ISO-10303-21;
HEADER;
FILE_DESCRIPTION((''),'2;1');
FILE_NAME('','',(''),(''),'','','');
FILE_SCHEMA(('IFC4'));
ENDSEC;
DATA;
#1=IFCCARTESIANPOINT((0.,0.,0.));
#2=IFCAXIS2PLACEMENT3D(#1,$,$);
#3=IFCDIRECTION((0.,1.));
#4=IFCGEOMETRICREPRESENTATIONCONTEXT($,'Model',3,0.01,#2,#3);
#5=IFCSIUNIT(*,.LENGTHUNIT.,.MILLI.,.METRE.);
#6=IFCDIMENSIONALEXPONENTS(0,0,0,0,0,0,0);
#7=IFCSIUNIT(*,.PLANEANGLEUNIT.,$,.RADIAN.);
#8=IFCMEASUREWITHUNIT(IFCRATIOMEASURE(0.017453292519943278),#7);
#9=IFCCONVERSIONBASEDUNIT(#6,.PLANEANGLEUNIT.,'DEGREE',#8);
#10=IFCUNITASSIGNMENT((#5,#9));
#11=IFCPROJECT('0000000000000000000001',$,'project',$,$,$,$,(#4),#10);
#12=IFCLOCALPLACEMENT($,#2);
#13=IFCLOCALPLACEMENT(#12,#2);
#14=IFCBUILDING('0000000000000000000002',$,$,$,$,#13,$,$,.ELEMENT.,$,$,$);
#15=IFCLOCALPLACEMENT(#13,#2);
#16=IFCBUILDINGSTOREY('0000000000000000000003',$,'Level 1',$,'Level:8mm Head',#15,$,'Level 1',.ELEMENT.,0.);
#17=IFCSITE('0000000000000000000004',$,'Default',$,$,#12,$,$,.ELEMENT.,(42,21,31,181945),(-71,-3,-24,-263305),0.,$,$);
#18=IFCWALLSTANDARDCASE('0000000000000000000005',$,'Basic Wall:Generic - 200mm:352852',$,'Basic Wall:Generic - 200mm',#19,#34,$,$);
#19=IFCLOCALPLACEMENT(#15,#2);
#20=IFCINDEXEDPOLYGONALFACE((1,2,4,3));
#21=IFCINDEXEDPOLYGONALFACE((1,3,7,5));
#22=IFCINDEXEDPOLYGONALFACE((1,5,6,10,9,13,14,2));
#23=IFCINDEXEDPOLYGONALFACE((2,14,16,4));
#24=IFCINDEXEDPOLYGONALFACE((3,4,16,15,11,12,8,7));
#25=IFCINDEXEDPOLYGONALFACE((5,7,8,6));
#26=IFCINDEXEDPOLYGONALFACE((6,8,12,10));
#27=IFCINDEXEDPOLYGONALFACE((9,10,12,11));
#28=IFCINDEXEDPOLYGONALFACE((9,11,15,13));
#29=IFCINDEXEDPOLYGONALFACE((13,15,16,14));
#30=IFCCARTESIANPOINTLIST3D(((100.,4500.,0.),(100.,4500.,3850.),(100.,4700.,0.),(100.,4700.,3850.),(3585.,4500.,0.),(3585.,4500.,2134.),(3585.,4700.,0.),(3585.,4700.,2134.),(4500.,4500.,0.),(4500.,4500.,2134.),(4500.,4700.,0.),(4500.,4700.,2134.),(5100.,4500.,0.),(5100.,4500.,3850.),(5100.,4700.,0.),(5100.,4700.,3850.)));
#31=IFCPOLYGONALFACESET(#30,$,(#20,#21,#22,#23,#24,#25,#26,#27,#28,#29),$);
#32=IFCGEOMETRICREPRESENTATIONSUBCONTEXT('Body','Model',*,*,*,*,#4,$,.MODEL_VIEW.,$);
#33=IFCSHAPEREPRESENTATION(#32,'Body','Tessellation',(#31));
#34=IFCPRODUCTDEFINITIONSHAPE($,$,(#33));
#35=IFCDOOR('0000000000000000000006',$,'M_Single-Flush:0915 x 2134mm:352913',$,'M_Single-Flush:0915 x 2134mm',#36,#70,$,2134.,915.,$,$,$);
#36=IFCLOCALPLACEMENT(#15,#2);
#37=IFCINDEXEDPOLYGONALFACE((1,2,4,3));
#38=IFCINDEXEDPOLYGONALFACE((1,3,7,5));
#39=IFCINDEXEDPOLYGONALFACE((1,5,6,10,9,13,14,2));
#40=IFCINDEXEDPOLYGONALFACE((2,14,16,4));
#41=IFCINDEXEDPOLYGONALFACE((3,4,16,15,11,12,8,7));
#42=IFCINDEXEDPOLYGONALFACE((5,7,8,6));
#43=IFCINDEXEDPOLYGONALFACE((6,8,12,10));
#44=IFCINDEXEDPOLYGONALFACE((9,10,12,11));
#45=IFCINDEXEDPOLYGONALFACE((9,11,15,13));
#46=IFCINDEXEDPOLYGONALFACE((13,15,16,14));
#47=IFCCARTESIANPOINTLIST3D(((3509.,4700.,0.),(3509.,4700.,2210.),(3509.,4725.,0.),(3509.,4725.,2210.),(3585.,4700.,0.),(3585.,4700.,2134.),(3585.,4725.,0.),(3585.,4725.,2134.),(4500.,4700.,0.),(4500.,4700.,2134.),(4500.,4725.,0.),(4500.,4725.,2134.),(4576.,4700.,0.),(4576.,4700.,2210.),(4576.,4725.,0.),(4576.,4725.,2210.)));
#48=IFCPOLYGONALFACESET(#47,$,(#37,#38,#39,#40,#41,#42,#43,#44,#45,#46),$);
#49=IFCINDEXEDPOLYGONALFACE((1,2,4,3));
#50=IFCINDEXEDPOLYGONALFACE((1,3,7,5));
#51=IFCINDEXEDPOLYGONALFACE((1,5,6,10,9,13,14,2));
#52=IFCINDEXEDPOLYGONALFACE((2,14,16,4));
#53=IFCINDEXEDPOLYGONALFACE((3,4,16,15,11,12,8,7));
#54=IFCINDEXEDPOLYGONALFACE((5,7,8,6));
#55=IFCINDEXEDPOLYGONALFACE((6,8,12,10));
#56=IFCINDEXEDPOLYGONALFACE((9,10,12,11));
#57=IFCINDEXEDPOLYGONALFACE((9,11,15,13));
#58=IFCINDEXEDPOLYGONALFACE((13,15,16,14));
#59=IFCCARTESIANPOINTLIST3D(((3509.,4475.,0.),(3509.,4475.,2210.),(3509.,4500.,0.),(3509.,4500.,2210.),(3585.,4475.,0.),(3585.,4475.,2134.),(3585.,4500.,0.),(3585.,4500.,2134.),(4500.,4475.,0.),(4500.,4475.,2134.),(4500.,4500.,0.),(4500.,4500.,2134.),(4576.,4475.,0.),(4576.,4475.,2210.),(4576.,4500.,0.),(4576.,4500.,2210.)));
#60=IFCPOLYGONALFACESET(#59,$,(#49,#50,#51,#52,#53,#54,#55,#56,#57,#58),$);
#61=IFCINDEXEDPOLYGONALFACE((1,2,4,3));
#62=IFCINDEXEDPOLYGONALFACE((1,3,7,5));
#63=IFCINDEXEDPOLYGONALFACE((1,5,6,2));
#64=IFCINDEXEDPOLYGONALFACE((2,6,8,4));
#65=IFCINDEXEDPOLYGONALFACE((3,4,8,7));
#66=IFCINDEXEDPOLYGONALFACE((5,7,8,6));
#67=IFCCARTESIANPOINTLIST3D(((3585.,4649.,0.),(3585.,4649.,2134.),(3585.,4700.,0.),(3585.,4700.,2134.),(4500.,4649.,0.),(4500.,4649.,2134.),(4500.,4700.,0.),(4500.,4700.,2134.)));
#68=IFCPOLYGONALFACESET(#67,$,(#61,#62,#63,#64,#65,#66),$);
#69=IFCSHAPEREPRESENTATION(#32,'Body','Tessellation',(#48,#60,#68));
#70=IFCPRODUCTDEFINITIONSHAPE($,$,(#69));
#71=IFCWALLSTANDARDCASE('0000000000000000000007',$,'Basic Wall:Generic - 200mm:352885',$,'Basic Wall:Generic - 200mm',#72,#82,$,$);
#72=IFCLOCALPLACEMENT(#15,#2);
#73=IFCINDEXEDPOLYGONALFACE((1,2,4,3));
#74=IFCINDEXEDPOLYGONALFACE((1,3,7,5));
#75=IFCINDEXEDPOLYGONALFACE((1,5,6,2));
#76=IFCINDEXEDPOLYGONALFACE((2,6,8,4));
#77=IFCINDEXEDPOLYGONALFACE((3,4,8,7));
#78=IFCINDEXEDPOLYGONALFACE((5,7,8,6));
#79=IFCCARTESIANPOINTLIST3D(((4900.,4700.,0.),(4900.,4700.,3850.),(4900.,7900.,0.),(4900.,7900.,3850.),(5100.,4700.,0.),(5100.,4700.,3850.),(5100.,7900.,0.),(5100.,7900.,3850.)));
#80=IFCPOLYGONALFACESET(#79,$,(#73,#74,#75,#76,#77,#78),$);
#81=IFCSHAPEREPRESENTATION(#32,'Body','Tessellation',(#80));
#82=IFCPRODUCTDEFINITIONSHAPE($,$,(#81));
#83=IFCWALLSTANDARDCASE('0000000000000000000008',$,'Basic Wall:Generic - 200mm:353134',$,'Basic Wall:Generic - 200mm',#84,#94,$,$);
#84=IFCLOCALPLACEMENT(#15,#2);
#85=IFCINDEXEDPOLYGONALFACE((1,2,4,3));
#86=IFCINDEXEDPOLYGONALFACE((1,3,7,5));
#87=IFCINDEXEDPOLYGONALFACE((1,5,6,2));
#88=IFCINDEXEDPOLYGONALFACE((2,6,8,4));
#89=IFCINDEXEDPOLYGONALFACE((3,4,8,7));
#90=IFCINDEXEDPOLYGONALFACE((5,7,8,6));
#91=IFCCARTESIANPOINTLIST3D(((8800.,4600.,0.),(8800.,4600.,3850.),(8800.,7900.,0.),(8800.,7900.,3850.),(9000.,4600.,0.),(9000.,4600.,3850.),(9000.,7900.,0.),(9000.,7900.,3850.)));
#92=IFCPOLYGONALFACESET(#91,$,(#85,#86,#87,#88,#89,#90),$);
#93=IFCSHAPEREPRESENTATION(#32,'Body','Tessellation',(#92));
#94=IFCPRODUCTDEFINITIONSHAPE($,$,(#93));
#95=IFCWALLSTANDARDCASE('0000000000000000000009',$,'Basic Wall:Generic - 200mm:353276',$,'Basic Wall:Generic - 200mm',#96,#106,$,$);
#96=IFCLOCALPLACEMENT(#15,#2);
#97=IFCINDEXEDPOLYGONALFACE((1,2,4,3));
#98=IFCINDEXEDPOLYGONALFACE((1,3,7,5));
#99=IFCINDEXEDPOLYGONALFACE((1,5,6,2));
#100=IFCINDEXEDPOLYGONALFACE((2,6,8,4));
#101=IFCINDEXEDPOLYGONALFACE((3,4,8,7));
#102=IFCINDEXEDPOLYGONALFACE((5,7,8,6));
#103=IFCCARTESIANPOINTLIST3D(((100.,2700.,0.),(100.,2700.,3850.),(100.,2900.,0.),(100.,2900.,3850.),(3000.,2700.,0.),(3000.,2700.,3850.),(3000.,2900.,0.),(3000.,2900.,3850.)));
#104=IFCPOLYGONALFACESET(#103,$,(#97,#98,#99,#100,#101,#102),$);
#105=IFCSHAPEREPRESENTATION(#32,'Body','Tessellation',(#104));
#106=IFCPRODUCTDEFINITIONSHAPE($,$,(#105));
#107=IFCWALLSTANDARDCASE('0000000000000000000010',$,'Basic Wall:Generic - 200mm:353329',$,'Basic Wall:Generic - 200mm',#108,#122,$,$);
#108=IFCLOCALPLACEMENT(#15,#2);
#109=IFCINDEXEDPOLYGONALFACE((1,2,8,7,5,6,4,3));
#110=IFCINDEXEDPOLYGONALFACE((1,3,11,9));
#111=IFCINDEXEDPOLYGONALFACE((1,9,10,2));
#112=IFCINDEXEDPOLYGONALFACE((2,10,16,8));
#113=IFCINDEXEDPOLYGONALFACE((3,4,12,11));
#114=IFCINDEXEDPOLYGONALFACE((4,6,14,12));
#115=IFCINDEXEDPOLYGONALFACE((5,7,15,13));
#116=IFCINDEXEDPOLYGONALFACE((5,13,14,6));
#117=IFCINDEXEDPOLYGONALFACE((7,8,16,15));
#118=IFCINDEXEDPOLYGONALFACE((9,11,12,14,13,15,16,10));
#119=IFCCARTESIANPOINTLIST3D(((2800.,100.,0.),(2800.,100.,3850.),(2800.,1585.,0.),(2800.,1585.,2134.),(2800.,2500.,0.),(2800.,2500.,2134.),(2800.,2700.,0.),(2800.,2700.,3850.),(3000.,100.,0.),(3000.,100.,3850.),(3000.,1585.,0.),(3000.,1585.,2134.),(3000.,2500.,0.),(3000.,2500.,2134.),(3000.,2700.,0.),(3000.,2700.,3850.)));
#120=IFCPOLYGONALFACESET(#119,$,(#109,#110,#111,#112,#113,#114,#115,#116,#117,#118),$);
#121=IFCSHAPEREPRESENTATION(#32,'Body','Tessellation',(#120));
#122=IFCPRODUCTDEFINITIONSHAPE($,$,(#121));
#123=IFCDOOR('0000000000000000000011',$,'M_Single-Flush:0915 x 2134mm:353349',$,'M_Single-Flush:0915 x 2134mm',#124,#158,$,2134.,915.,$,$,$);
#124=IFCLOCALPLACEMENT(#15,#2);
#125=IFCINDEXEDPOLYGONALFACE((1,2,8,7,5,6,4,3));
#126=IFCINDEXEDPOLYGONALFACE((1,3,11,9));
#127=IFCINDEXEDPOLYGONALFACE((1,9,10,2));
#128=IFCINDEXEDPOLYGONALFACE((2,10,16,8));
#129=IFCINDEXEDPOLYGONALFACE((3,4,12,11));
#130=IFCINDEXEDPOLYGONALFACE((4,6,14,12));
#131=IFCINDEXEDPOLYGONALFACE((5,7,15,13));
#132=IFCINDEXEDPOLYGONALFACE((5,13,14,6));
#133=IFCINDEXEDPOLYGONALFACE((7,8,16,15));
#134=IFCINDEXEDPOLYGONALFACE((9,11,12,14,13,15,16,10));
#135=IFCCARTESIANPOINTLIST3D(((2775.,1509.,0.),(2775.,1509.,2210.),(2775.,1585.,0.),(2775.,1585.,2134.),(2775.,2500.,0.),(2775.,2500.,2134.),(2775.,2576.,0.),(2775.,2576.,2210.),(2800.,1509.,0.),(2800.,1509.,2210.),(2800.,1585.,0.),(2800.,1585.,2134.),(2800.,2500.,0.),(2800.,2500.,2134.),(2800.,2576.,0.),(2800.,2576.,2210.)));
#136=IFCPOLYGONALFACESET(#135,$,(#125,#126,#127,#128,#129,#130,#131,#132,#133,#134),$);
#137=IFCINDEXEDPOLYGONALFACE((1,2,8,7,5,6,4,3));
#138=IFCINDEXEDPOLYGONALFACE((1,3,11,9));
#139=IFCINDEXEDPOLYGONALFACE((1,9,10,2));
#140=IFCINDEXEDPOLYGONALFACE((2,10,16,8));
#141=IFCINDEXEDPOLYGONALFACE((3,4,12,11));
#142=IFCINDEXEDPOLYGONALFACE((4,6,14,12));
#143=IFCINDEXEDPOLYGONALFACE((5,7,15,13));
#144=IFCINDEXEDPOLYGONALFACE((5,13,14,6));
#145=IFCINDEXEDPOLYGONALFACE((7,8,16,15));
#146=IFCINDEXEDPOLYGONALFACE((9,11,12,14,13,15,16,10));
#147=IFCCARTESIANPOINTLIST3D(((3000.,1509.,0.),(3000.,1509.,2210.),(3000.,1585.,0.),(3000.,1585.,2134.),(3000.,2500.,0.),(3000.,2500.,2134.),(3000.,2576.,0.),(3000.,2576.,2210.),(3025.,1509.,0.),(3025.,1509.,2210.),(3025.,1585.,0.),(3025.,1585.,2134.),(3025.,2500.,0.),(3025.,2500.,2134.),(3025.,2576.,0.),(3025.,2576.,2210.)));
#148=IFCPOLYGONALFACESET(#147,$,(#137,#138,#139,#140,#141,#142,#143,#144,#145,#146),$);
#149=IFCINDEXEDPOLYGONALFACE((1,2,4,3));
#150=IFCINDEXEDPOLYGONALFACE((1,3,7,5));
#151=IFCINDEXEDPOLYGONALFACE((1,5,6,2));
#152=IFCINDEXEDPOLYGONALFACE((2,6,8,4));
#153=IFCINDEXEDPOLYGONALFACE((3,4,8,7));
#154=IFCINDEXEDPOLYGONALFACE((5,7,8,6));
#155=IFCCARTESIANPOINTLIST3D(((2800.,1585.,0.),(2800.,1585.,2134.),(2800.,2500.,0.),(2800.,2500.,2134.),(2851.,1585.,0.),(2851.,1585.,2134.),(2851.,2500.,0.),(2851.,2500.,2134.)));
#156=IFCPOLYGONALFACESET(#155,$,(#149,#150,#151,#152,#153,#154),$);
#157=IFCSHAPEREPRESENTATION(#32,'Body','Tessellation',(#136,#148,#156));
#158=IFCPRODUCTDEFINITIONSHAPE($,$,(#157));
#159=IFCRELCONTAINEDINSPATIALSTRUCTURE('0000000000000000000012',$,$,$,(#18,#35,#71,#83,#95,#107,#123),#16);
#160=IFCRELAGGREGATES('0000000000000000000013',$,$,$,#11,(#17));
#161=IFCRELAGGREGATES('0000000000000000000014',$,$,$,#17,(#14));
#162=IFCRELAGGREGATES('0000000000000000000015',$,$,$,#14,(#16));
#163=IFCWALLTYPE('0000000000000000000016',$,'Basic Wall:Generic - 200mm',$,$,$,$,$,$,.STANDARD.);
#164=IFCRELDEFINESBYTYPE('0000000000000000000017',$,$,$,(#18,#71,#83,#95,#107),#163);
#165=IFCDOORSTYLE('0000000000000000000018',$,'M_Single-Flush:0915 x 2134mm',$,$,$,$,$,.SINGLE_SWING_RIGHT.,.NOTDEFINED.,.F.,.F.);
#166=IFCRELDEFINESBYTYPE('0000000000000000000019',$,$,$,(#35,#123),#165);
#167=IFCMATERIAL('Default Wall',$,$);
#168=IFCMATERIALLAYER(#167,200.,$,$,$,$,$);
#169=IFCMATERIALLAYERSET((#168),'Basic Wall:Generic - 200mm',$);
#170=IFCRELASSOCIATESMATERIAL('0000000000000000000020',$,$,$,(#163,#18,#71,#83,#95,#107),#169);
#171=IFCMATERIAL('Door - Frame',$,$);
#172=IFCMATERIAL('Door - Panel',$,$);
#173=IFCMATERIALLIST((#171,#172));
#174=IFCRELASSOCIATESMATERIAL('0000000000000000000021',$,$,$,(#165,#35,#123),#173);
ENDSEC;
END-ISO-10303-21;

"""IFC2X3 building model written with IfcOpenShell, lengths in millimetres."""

from ifc_helpers import new_model, entity, si_unit, converted_unit, direction, frame, frame_2d, origin, place, context, subcontext, project, spatial, polyline, rectangle, outline, extrude, clip, bounded_halfspace, source, transform, mapped, material, material_list, layer, layer_set, layer_usage, type_object, type_shapes, element, fill, save


model = new_model("IFC2X3")

# Units and contexts
model_context = context("Model", 3, precision=0.01, world=origin(), true_north=direction((0.0, 1.0)))
body_context = subcontext(model_context, "Body", "Model", "MODEL_VIEW")
ifc_project = project(units=[si_unit("LENGTHUNIT", "METRE", prefix="MILLI"), converted_unit("PLANEANGLEUNIT", "DEGREE", entity("IfcRatioMeasure", 0.017453292519943278), si_unit("PLANEANGLEUNIT", "RADIAN"), dimensions=[0, 0, 0, 0, 0, 0, 0])], contexts=[model_context])

# Site, building, storey
site_placement = place(None, origin())
site = spatial("IfcSite", under=ifc_project, at=site_placement, Name="Default", CompositionType="ELEMENT", RefLatitude=(42, 21, 31, 181945), RefLongitude=(-71, -3, -24, -263305), RefElevation=0.0)
building_placement = place(site_placement, origin())
building = spatial("IfcBuilding", under=site, at=building_placement, CompositionType="ELEMENT")
storey_placement = place(building_placement, origin())
storey = spatial("IfcBuildingStorey", under=building, at=storey_placement, Name="Level 1", ObjectType="Level:8mm Head", LongName="Level 1", CompositionType="ELEMENT", Elevation=0.0)

# Shared definitions
ifc_material_1 = material(Name="Default Wall")
ifc_layer_1 = layer(ifc_material_1, 200.0)
ifc_layer_set_1 = layer_set([ifc_layer_1], Name="Basic Wall:Generic - 200mm")
ifc_layer_usage_1 = layer_usage(ifc_layer_set_1, "AXIS2", "NEGATIVE", 100.0)
wall_type = type_object("IfcWallType", Name="Basic Wall:Generic - 200mm", PredefinedType="STANDARD", material=ifc_layer_set_1)
ifc_material_2 = material(Name="Door - Frame")
ifc_material_3 = material(Name="Door - Panel")
ifc_material_list = material_list([ifc_material_2, ifc_material_3])
door_style = type_object("IfcDoorStyle", Name="M_Single-Flush:0915 x 2134mm", ConstructionType="NOTDEFINED", OperationType="SINGLE_SWING_RIGHT", ParameterTakesPrecedence=False, Sizeable=False, material=ifc_material_list)
shared_shape = source(origin(), body_context, "Body", "SweptSolid", [
    extrude(outline(polyline([(-533.5, -1124.0), (533.5, -1124.0), (533.5, 1086.0), (457.5, 1086.0), (457.5, -1048.0), (-457.5, -1048.0), (-457.5, 1086.0), (-533.5, 1086.0), (-533.5, -1124.0)])), frame((457.5, 200.0, 1086.0), z_axis=(0.0, 1.0, 0.0), x_axis=(1.0, 0.0, 0.0)), (0.0, 0.0, 1.0), 25.0),
    extrude(outline(polyline([(-1124.0, -533.5), (1086.0, -533.5), (1086.0, -457.5), (-1048.0, -457.5), (-1048.0, 457.5), (1086.0, 457.5), (1086.0, 533.5), (-1124.0, 533.5), (-1124.0, -533.5)])), frame((457.5, -25.0, 1086.0), z_axis=(0.0, 1.0, 0.0), x_axis=(0.0, 0.0, -1.0)), (0.0, 0.0, 1.0), 25.0),
    extrude(rectangle(XDim=51.0, YDim=915.0, at=frame_2d((0.0, 0.0), x_axis=(1.0, 0.0))), frame((457.5, 174.5, 0.0), z_axis=(0.0, 0.0, 1.0), x_axis=(0.0, 1.0, 0.0)), (0.0, 0.0, 1.0), 2134.0),
])
type_shapes(door_style, [shared_shape])

# Wall, opening, door
wall_1_placement = place(storey_placement, frame((100.0, 4600.0, 0.0)))
wall_1 = element("IfcWallStandardCase", 1, at=wall_1_placement, inside=storey, type_object=wall_type, material=ifc_layer_usage_1, Name="Basic Wall:Generic - 200mm:352852", ObjectType="Basic Wall:Generic - 200mm", context=body_context, shape_type="Clipping", body=[
    clip(extrude(rectangle(XDim=5000.0, YDim=200.0, at=frame_2d((2500.0, 0.0), x_axis=(1.0, 0.0))), origin(), (0.0, 0.0, 1.0), 3850.0), bounded_halfspace(frame((0.0, -100.0, 3850.0), z_axis=(0.0, 0.0, -1.0), x_axis=(0.0, -1.0, 0.0)), True, frame((0.0, -100.0, 3850.0)), polyline([(0.0, 0.0), (5000.0, 0.0), (5000.0, 200.0), (4800.0, 200.0), (0.0, 200.0), (0.0, 0.0)]))),
])
opening_1_placement = place(wall_1_placement, frame((3485.0, -100.0, 0.0)))
opening_1 = element("IfcOpeningElement", 2, at=opening_1_placement, cuts=wall_1, ObjectType="Opening", context=body_context, shape_type="SweptSolid", body=[
    extrude(rectangle(XDim=915.0, YDim=2134.0, at=frame_2d((1067.0, 457.5), x_axis=(0.0, 1.0))), frame((0.0, 0.0, 0.0), z_axis=(0.0, 1.0, 0.0), x_axis=(0.0, 0.0, 1.0)), (0.0, 0.0, 1.0), 200.0),
])
door_1_placement = place(opening_1_placement, origin())
door_1 = element("IfcDoor", 3, at=door_1_placement, inside=storey, type_object=door_style, material=ifc_material_list, Name="M_Single-Flush:0915 x 2134mm:352913", ObjectType="M_Single-Flush:0915 x 2134mm", OverallHeight=2134.0, OverallWidth=915.0, context=body_context, shape_type="MappedRepresentation", body=[
    mapped(shared_shape, transform((0.0, 0.0, 0.0), scale=1.0)),
])
fill(opening_1, door_1)

# Walls
wall_2_placement = place(storey_placement, frame((5000.0, 4700.0, 0.0), z_axis=(0.0, 0.0, 1.0), x_axis=(0.0, 1.0, 0.0)))
element("IfcWallStandardCase", 4, at=wall_2_placement, inside=storey, type_object=wall_type, material=ifc_layer_usage_1, Name="Basic Wall:Generic - 200mm:352885", ObjectType="Basic Wall:Generic - 200mm", context=body_context, shape_type="Clipping", body=[
    clip(extrude(rectangle(XDim=3200.0, YDim=200.0, at=frame_2d((1600.0, 0.0), x_axis=(-1.0, 0.0))), origin(), (0.0, 0.0, 1.0), 3850.0), bounded_halfspace(frame((0.0, -100.0, 3850.0), z_axis=(0.0, 0.0, -1.0), x_axis=(-1.0, 0.0, 0.0)), True, frame((0.0, -100.0, 3850.0)), polyline([(0.0, 0.0), (3200.0, 0.0), (3200.0, 200.0), (0.0, 200.0), (0.0, 0.0)]))),
])
wall_3_placement = place(storey_placement, frame((8900.0, 7900.0, 0.0), z_axis=(0.0, 0.0, 1.0), x_axis=(0.0, -1.0, 0.0)))
element("IfcWallStandardCase", 5, at=wall_3_placement, inside=storey, type_object=wall_type, material=ifc_layer_usage_1, Name="Basic Wall:Generic - 200mm:353134", ObjectType="Basic Wall:Generic - 200mm", context=body_context, shape_type="Clipping", body=[
    clip(extrude(rectangle(XDim=3300.0, YDim=200.0, at=frame_2d((1650.0, 0.0), x_axis=(-1.0, 0.0))), origin(), (0.0, 0.0, 1.0), 3850.0), bounded_halfspace(frame((0.0, -100.0, 3850.0), z_axis=(0.0, 0.0, -1.0), x_axis=(1.0, 0.0, 0.0)), True, frame((0.0, -100.0, 3850.0)), polyline([(0.0, 0.0), (3300.0, 0.0), (3300.0, 200.0), (0.0, 200.0), (0.0, 0.0)]))),
])
wall_4_placement = place(storey_placement, frame((100.0, 2800.0, 0.0)))
element("IfcWallStandardCase", 6, at=wall_4_placement, inside=storey, type_object=wall_type, material=ifc_layer_usage_1, Name="Basic Wall:Generic - 200mm:353276", ObjectType="Basic Wall:Generic - 200mm", context=body_context, shape_type="Clipping", body=[
    clip(extrude(rectangle(XDim=2900.0, YDim=200.0, at=frame_2d((1450.0, 0.0), x_axis=(-1.0, 0.0))), origin(), (0.0, 0.0, 1.0), 3850.0), bounded_halfspace(frame((0.0, -100.0, 3850.0), z_axis=(0.0, 0.0, -1.0), x_axis=(0.0, -1.0, 0.0)), True, frame((0.0, -100.0, 3850.0)), polyline([(0.0, 0.0), (2700.0, 0.0), (2900.0, 0.0), (2900.0, 200.0), (0.0, 200.0), (0.0, 0.0)]))),
])

# Wall, opening, door
wall_5_placement = place(storey_placement, frame((2900.0, 2700.0, 0.0), z_axis=(0.0, 0.0, 1.0), x_axis=(0.0, -1.0, 0.0)))
wall_5 = element("IfcWallStandardCase", 7, at=wall_5_placement, inside=storey, type_object=wall_type, material=ifc_layer_usage_1, Name="Basic Wall:Generic - 200mm:353329", ObjectType="Basic Wall:Generic - 200mm", context=body_context, shape_type="Clipping", body=[
    clip(extrude(rectangle(XDim=2600.0, YDim=200.0, at=frame_2d((1300.0, 0.0), x_axis=(-1.0, 0.0))), origin(), (0.0, 0.0, 1.0), 3850.0), bounded_halfspace(frame((0.0, -100.0, 3850.0), z_axis=(0.0, 0.0, -1.0), x_axis=(1.0, 0.0, 0.0)), True, frame((0.0, -100.0, 3850.0)), polyline([(0.0, 0.0), (2600.0, 0.0), (2600.0, 200.0), (0.0, 200.0), (0.0, 0.0)]))),
])
opening_2_placement = place(wall_5_placement, frame((1115.0, 100.0, 0.0)))
opening_2 = element("IfcOpeningElement", 8, at=opening_2_placement, cuts=wall_5, ObjectType="Opening", context=body_context, shape_type="SweptSolid", body=[
    extrude(rectangle(XDim=915.0, YDim=2134.0, at=frame_2d((1067.0, 457.5), x_axis=(0.0, 1.0))), frame((0.0, 0.0, 0.0), z_axis=(0.0, -1.0, 0.0), x_axis=(0.0, 0.0, 1.0)), (0.0, 0.0, 1.0), 200.0),
])
door_2_placement = place(opening_2_placement, frame((0.0, 0.0, 0.0), z_axis=(0.0, 0.0, 1.0), x_axis=(-1.0, 0.0, 0.0)))
door_2 = element("IfcDoor", 9, at=door_2_placement, inside=storey, type_object=door_style, material=ifc_material_list, Name="M_Single-Flush:0915 x 2134mm:353349", ObjectType="M_Single-Flush:0915 x 2134mm", OverallHeight=2134.0, OverallWidth=915.0, context=body_context, shape_type="MappedRepresentation", body=[
    mapped(shared_shape, transform((0.0, 0.0, 0.0), scale=1.0)),
])
fill(opening_2, door_2)

save(model, "model.ifc")
